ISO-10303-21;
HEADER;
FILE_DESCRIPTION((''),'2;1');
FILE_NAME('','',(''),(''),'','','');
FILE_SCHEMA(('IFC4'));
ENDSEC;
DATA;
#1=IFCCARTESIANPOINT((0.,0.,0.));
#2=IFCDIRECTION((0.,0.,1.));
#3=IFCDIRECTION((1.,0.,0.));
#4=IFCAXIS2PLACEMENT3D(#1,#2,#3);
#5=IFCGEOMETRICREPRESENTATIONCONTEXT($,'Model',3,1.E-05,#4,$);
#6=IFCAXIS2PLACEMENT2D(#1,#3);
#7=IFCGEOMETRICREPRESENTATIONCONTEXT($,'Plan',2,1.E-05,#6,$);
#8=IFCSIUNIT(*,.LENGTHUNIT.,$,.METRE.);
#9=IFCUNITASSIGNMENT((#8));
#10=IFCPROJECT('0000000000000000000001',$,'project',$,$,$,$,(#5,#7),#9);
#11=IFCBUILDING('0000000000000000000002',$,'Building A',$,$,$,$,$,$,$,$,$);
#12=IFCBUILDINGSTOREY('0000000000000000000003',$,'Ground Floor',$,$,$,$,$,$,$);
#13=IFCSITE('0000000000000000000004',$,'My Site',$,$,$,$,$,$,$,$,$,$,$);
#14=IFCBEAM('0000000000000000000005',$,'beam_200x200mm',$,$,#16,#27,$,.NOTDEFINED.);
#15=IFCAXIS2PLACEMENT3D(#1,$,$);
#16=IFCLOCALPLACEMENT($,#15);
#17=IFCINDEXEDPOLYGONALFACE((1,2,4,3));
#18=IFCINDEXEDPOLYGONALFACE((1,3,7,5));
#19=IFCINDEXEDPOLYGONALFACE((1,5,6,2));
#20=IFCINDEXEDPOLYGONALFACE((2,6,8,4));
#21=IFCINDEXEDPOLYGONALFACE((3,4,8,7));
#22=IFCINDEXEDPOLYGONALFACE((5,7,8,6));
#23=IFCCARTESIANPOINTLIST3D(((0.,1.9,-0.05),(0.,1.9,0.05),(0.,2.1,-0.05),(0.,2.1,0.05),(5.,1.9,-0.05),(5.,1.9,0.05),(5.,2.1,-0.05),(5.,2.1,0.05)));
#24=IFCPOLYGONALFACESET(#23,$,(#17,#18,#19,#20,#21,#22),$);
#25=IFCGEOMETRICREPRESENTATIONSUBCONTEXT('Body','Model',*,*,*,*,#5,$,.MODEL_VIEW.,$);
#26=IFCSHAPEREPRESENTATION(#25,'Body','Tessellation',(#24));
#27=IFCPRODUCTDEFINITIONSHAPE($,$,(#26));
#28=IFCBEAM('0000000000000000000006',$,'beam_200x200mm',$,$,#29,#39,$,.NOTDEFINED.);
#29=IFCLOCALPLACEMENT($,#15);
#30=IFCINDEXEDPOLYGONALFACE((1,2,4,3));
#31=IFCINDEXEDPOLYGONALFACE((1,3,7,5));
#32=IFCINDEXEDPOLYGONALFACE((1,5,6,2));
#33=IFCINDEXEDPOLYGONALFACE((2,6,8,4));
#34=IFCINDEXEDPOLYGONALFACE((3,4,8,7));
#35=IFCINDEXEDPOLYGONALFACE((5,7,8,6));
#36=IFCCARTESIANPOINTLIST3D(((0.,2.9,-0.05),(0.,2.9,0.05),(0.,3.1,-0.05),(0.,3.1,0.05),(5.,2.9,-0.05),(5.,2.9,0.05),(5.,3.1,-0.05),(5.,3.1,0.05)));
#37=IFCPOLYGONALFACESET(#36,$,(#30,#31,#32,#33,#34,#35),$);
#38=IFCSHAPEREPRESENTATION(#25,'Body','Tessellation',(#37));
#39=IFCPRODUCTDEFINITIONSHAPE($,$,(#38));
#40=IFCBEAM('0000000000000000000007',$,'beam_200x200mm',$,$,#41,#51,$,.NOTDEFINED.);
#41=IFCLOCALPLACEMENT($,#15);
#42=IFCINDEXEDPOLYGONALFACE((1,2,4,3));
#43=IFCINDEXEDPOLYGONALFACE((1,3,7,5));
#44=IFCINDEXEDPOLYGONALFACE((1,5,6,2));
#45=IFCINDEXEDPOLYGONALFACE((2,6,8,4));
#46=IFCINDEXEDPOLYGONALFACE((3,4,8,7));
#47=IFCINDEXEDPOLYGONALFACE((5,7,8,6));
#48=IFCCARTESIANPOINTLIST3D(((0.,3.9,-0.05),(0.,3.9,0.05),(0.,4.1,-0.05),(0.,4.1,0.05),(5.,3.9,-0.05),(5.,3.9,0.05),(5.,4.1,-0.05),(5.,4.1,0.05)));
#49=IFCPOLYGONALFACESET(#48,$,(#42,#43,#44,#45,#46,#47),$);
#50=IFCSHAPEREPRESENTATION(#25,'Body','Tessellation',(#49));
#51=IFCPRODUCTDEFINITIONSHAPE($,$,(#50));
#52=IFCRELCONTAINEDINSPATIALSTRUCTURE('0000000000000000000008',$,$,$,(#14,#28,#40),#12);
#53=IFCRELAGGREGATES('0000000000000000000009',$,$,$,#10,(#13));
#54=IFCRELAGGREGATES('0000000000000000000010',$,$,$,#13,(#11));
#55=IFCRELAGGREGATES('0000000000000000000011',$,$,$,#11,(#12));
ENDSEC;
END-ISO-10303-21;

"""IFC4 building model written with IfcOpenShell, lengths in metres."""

from ifc_helpers import new_model, si_unit, frame, frame_2d, origin_with_axes, place, context, subcontext, project, spatial, rectangle, extrude, element, save


model = new_model("IFC4")

# Units and contexts
model_context = context("Model", 3, precision=1e-05, world=origin_with_axes())
plan_context = context("Plan", 2, precision=1e-05, world=frame_2d((0.0, 0.0, 0.0), x_axis=(1.0, 0.0, 0.0)))
body_context = subcontext(model_context, "Body", "Model", "MODEL_VIEW")
ifc_project = project(units=[si_unit("LENGTHUNIT", "METRE")], contexts=[model_context, plan_context])

# Site, building, storey
site = spatial("IfcSite", under=ifc_project, Name="My Site")
building = spatial("IfcBuilding", under=site, Name="Building A")
storey = spatial("IfcBuildingStorey", under=building, Name="Ground Floor")

# Beams
for number, where, z_axis, x_axis, name in (
    (1, (0.0, 2.0, 0.0), (1.0, 0.0, 0.0), (0.0, 0.0, 1.0), "beam_200x200mm"),
    (2, (0.0, 3.0, 0.0), (1.0, 0.0, 0.0), (0.0, 0.0, 1.0), "beam_200x200mm"),
    (3, (0.0, 4.0, 0.0), (1.0, 0.0, 0.0), (0.0, 0.0, 1.0), "beam_200x200mm"),
):
    element("IfcBeam", number, at=place(None, frame(where, z_axis=z_axis, x_axis=x_axis)), inside=storey, Name=name, PredefinedType="NOTDEFINED", context=body_context, shape_type="SweptSolid", body=[
        extrude(rectangle(XDim=0.1, YDim=0.2), origin_with_axes(), (0.0, 0.0, 1.0), 5.0),
    ])

save(model, "model.ifc")
